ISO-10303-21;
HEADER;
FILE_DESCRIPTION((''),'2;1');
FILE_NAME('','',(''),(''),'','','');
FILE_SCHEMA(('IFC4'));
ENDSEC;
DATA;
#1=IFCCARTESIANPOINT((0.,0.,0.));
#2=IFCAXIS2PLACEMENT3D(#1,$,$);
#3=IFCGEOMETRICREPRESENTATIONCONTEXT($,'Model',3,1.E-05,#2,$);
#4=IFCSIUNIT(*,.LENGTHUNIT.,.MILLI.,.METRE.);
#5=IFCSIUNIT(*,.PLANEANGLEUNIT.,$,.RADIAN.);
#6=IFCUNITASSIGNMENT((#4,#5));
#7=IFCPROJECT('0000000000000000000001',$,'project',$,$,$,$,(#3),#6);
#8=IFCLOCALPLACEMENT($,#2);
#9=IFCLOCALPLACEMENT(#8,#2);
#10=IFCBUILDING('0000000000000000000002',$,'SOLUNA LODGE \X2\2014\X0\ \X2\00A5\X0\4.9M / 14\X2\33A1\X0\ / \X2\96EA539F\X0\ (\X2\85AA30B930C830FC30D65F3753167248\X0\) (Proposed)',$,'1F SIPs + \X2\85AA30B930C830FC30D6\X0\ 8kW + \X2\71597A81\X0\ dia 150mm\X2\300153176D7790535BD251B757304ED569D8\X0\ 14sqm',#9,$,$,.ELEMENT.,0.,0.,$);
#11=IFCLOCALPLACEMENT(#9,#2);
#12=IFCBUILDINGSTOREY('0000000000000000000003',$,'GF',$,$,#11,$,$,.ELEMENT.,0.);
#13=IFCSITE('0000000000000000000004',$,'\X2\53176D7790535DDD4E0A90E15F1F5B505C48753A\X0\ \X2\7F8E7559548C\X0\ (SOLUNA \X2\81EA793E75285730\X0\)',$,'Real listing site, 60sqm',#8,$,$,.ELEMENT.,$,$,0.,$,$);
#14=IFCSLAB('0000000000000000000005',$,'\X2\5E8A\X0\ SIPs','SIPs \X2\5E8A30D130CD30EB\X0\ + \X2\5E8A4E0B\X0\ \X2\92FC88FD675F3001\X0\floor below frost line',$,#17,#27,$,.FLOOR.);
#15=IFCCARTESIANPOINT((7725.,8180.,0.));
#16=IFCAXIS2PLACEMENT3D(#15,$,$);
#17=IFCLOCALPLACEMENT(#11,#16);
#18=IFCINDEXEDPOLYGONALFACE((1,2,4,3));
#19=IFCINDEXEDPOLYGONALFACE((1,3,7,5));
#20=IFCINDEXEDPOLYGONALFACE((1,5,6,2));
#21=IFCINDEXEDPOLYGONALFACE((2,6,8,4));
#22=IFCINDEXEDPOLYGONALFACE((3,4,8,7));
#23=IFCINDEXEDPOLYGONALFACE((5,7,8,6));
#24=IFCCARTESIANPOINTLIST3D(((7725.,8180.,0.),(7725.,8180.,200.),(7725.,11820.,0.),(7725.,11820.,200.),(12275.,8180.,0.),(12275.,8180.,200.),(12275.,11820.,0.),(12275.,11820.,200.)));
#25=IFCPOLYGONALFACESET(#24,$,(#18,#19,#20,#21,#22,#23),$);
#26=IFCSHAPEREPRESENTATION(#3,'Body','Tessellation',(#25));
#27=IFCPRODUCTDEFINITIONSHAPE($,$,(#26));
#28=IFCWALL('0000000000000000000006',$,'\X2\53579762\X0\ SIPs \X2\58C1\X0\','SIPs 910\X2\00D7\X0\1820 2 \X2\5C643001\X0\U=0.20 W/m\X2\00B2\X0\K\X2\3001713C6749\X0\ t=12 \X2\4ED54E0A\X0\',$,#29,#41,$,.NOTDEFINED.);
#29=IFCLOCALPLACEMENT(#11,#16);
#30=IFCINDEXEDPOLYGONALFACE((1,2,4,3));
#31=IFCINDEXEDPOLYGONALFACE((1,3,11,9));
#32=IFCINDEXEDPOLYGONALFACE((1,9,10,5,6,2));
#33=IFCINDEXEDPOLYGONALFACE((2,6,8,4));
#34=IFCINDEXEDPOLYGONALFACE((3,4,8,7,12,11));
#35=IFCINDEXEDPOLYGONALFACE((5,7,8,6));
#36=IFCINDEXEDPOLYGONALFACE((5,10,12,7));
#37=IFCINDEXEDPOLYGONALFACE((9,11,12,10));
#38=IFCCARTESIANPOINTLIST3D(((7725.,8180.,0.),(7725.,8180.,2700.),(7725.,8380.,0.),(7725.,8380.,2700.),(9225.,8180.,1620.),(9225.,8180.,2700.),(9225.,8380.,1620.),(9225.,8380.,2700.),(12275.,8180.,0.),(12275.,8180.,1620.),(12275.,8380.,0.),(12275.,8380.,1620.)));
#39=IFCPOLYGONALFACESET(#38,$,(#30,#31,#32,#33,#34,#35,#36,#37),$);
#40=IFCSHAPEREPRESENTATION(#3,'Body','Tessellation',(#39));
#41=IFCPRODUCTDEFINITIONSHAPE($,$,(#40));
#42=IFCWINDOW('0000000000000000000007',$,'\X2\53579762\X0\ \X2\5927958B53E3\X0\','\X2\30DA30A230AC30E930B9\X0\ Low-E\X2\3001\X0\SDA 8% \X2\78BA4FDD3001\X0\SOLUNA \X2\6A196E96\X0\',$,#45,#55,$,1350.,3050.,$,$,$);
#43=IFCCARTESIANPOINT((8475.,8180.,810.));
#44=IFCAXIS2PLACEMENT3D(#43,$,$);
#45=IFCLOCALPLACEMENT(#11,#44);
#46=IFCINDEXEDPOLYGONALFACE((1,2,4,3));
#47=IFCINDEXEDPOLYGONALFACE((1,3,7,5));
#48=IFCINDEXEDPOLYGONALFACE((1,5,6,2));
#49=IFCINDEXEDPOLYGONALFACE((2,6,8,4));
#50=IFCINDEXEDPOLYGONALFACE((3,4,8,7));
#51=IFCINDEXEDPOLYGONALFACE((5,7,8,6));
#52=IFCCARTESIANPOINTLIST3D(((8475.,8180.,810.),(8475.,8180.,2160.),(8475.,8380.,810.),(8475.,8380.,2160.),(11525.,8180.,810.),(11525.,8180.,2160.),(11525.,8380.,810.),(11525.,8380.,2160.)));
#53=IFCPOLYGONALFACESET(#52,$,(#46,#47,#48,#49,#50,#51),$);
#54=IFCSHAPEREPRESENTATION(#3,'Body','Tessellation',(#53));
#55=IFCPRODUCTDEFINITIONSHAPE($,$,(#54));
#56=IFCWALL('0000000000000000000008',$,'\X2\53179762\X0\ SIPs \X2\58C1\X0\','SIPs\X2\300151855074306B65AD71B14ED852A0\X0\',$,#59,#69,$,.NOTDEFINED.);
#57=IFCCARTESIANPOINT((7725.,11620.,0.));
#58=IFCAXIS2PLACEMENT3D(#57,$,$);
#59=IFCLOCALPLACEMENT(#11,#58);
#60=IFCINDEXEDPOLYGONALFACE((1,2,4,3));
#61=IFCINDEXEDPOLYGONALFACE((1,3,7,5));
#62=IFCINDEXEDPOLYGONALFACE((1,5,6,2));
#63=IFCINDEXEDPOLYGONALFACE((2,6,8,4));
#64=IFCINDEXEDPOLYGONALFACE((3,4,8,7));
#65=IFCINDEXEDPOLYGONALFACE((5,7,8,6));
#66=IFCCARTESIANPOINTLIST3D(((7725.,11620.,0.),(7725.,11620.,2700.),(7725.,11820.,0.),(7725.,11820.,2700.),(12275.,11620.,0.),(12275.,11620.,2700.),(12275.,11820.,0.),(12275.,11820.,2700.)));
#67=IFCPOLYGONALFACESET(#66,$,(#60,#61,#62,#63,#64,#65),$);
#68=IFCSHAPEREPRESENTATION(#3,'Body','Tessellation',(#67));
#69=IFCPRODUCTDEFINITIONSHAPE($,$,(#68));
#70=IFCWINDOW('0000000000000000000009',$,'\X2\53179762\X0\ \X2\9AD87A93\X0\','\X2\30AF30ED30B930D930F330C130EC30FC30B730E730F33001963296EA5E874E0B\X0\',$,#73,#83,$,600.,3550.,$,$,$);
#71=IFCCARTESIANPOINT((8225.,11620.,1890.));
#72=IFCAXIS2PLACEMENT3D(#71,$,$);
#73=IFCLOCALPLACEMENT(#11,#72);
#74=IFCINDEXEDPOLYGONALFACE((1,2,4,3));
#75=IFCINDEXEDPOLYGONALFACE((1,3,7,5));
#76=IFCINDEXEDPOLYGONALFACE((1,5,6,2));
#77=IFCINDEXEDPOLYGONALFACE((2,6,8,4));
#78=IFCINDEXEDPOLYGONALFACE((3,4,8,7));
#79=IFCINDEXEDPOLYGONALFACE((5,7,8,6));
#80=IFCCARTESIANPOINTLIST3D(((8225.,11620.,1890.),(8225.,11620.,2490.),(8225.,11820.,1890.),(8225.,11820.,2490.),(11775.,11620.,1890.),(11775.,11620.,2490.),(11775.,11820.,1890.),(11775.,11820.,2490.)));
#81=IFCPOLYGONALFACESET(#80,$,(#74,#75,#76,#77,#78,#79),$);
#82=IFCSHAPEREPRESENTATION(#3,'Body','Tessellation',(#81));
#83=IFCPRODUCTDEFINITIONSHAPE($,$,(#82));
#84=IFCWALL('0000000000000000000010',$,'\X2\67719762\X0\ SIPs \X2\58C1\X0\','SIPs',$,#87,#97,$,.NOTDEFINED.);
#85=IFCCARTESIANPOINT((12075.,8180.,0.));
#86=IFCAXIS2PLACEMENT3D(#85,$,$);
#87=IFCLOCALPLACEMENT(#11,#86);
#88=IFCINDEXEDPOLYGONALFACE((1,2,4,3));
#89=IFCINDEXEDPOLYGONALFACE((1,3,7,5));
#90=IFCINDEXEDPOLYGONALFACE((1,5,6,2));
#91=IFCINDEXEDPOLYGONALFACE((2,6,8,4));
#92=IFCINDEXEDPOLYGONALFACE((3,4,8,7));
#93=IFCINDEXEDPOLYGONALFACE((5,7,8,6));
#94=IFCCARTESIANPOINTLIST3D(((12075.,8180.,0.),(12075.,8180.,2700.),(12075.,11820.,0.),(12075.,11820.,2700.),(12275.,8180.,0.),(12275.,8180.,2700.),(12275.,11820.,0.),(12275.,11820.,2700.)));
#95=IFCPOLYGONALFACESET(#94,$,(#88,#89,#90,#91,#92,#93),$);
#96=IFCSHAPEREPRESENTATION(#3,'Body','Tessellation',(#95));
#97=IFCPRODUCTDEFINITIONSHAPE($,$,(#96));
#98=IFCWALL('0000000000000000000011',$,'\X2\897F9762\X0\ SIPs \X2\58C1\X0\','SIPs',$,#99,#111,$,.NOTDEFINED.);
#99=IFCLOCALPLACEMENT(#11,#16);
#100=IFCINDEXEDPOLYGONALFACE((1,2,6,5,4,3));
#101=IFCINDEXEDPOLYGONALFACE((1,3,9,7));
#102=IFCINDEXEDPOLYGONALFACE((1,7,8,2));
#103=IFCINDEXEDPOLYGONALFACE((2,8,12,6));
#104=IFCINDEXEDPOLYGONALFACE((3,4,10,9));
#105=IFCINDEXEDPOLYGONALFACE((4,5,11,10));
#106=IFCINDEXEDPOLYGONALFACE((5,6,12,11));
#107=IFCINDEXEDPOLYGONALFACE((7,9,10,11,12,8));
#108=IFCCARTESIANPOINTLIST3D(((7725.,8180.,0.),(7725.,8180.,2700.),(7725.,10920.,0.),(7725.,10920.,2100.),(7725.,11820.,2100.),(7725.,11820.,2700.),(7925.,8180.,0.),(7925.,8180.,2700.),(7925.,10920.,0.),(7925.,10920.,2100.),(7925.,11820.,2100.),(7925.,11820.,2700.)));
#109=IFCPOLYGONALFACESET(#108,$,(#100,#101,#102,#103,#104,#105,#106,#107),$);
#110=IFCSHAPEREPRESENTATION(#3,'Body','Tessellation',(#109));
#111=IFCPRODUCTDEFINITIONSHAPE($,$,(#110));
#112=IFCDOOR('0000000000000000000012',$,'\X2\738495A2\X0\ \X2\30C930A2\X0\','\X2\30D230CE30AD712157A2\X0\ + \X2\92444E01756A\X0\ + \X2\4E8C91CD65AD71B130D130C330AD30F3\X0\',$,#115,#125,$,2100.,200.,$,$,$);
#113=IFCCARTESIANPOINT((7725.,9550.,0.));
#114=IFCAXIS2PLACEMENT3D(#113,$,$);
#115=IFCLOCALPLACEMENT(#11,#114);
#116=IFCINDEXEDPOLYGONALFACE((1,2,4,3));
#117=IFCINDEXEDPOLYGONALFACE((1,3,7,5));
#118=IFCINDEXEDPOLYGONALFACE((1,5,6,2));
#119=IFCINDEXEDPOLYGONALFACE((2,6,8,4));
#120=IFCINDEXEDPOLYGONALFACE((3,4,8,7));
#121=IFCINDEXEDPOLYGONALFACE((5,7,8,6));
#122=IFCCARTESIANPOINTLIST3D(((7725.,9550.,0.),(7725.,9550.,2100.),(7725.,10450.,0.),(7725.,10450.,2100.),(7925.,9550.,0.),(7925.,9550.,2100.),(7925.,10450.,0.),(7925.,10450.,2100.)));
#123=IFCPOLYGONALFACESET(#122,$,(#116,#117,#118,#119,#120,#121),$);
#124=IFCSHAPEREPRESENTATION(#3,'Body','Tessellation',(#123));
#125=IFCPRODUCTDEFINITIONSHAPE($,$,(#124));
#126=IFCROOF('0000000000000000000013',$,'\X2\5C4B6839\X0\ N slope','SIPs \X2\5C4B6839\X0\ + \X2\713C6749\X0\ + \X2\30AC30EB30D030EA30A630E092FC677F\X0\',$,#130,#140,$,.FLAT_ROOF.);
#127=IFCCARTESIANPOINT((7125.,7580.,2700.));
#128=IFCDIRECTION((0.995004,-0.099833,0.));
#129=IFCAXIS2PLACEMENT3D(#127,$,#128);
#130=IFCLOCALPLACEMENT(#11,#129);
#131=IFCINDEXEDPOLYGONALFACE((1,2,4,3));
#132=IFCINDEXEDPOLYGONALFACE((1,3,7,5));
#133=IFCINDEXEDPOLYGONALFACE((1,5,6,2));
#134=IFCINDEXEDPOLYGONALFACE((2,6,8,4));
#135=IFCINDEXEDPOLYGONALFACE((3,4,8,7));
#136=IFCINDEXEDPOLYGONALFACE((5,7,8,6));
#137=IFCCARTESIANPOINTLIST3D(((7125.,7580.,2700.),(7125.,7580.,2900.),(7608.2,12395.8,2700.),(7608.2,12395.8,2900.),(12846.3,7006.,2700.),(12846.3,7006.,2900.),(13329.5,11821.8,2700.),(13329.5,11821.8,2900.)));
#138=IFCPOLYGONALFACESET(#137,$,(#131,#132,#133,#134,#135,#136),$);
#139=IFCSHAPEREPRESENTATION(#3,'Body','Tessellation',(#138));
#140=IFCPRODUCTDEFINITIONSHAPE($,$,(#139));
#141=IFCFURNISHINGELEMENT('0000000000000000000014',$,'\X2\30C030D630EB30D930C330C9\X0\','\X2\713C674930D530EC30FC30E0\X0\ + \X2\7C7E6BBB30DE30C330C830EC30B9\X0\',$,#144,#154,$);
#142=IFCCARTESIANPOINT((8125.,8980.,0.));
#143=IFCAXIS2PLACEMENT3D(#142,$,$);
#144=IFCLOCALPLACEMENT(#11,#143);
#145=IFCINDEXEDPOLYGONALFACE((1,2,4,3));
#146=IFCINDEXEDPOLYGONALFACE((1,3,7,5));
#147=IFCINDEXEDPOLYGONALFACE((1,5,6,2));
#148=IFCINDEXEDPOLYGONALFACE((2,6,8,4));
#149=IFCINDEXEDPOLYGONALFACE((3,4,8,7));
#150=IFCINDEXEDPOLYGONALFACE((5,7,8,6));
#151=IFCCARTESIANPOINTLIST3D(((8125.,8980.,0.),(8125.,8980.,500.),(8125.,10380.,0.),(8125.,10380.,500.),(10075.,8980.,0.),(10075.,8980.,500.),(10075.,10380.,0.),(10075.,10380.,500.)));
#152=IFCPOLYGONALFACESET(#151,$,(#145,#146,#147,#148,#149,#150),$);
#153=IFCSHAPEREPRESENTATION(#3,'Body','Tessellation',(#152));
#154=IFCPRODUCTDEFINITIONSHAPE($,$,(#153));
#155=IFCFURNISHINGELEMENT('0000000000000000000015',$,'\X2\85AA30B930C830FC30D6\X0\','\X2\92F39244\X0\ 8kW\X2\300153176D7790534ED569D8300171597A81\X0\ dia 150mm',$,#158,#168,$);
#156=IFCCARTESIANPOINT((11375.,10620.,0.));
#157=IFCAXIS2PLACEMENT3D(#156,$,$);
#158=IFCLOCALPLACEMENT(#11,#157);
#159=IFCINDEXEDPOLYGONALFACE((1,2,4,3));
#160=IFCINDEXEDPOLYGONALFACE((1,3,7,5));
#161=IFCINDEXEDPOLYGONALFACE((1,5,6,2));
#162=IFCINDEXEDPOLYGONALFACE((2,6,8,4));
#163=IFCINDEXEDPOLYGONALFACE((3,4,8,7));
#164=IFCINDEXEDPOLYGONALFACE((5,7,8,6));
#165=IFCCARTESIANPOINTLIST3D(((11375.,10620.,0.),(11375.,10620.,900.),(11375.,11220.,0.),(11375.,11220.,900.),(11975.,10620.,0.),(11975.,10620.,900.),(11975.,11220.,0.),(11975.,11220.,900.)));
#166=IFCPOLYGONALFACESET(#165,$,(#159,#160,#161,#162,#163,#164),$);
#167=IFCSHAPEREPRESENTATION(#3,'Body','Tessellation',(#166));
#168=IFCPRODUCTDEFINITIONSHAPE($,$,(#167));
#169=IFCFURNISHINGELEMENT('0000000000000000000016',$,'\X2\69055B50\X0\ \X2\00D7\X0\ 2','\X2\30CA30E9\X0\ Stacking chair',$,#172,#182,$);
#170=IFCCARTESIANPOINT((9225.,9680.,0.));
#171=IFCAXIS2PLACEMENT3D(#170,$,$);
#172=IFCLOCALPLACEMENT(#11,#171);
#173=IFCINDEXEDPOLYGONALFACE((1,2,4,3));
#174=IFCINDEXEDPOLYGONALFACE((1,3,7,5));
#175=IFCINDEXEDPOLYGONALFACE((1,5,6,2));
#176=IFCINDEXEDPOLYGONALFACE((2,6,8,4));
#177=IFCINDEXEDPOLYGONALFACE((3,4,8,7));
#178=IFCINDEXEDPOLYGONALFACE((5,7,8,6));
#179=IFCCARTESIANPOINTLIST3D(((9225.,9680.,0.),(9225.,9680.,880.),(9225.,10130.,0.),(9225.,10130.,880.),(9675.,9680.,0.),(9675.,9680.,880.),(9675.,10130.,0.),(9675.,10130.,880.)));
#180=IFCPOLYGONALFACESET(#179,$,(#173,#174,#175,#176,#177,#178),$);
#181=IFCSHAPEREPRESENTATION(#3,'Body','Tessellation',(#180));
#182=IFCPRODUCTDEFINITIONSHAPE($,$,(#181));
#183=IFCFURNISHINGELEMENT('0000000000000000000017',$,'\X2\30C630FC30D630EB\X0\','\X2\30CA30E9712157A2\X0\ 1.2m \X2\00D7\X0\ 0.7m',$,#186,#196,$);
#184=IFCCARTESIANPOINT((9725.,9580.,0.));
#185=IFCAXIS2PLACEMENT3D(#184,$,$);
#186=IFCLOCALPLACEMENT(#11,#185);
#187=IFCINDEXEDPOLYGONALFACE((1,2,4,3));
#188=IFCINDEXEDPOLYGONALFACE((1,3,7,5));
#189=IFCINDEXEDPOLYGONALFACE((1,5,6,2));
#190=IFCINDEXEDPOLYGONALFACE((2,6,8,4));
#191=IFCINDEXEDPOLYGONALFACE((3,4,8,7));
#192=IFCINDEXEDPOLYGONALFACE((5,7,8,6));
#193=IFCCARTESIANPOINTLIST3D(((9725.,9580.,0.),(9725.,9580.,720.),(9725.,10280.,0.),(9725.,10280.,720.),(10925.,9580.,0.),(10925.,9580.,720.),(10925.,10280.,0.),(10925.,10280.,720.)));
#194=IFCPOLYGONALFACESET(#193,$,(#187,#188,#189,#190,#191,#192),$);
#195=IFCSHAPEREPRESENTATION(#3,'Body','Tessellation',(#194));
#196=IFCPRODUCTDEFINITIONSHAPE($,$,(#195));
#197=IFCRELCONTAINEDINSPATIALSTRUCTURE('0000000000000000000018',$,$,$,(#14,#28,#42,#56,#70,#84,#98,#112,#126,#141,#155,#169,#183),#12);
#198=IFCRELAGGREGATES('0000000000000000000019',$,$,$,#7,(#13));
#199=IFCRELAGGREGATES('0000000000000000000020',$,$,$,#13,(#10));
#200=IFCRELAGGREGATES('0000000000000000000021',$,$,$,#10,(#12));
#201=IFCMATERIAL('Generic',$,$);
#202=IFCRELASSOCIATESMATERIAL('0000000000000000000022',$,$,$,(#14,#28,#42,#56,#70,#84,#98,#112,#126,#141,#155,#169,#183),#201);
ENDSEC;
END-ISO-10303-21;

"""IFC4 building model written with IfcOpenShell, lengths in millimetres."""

from ifc_helpers import new_model, si_unit, frame, frame_2d, origin, place, context, project, spatial, rectangle, extrude, material, element, fill, save


model = new_model("IFC4")

# Units and contexts
model_context = context("Model", 3, precision=1e-05, world=origin())
ifc_project = project(units=[si_unit("LENGTHUNIT", "METRE", prefix="MILLI"), si_unit("PLANEANGLEUNIT", "RADIAN")], contexts=[model_context])

# Site, building, storey
site_placement = place(None, origin())
site = spatial("IfcSite", under=ifc_project, at=site_placement, Name="北海道川上郡弟子屈町 美留和 (SOLUNA 自社用地)", ObjectType="Real listing site, 60sqm", CompositionType="ELEMENT", RefElevation=0.0)
building_placement = place(site_placement, origin())
building = spatial("IfcBuilding", under=site, at=building_placement, Name="SOLUNA LODGE — ¥4.9M / 14㎡ / 雪原 (薪ストーブ強化版) (Proposed)", ObjectType="1F SIPs + 薪ストーブ 8kW + 煙突 dia 150mm、北海道寒冷地仕様 14sqm", CompositionType="ELEMENT", ElevationOfRefHeight=0.0, ElevationOfTerrain=0.0)
storey_placement = place(building_placement, origin())
storey = spatial("IfcBuildingStorey", under=building, at=storey_placement, Name="GF", CompositionType="ELEMENT", Elevation=0.0)

# Slab
ifc_material = material(Name="Generic")
slab_placement = place(storey_placement, frame((7725.0, 8180.0, 0.0)))
element("IfcSlab", 1, at=slab_placement, inside=storey, material=ifc_material, Name="床 SIPs", Description="SIPs 床パネル + 床下 鋼製束、floor below frost line", PredefinedType="FLOOR", context=model_context, shape_type="SweptSolid", body=[
    extrude(rectangle(XDim=4550.0, YDim=3640.0, at=frame_2d((2275.0, 1820.0))), frame((7725.0, 8180.0, 0.0)), (0.0, 0.0, 1.0), 200.0),
])

# Walls, openings, windows
wall_1_placement = place(storey_placement, frame((7725.0, 8180.0, 0.0)))
wall_1 = element("IfcWall", 2, at=wall_1_placement, inside=storey, material=ifc_material, Name="南面 SIPs 壁", Description="SIPs 910×1820 2 層、U=0.20 W/m²K、焼杉 t=12 仕上", PredefinedType="NOTDEFINED", context=model_context, shape_type="SweptSolid", body=[
    extrude(rectangle(XDim=4550.0, YDim=200.0, at=frame_2d((2275.0, 100.0))), frame((7725.0, 8180.0, 0.0)), (0.0, 0.0, 1.0), 2700.0),
])
opening_1_placement = place(storey_placement, frame((8475.0, 8180.0, 810.0)))
opening_1 = element("IfcOpeningElement", 3, at=opening_1_placement, cuts=wall_1, PredefinedType="NOTDEFINED", context=model_context, shape_type="SweptSolid", body=[
    extrude(rectangle(XDim=3050.0, YDim=200.0, at=frame_2d((1525.0, 100.0))), frame((8475.0, 8180.0, 810.0)), (0.0, 0.0, 1.0), 1350.0),
])
window_1_placement = place(storey_placement, frame((8475.0, 8180.0, 810.0)))
window_1 = element("IfcWindow", 4, at=window_1_placement, inside=storey, material=ifc_material, Name="南面 大開口", Description="ペアガラス Low-E、SDA 8% 確保、SOLUNA 標準", OverallHeight=1350.0, OverallWidth=3050.0, context=model_context, shape_type="SweptSolid", body=[
    extrude(rectangle(XDim=3050.0, YDim=200.0, at=frame_2d((1525.0, 100.0))), frame((8475.0, 8180.0, 810.0)), (0.0, 0.0, 1.0), 1350.0),
])
fill(opening_1, window_1)
wall_2_placement = place(storey_placement, frame((7725.0, 11620.0, 0.0)))
wall_2 = element("IfcWall", 5, at=wall_2_placement, inside=storey, material=ifc_material, Name="北面 SIPs 壁", Description="SIPs、内側に断熱付加", PredefinedType="NOTDEFINED", context=model_context, shape_type="SweptSolid", body=[
    extrude(rectangle(XDim=4550.0, YDim=200.0, at=frame_2d((2275.0, 100.0))), frame((7725.0, 11620.0, 0.0)), (0.0, 0.0, 1.0), 2700.0),
])
opening_2_placement = place(storey_placement, frame((8225.0, 11620.0, 1890.0)))
opening_2 = element("IfcOpeningElement", 6, at=opening_2_placement, cuts=wall_2, PredefinedType="NOTDEFINED", context=model_context, shape_type="SweptSolid", body=[
    extrude(rectangle(XDim=3550.0, YDim=200.0, at=frame_2d((1775.0, 100.0))), frame((8225.0, 11620.0, 1890.0)), (0.0, 0.0, 1.0), 600.0),
])
window_2_placement = place(storey_placement, frame((8225.0, 11620.0, 1890.0)))
window_2 = element("IfcWindow", 7, at=window_2_placement, inside=storey, material=ifc_material, Name="北面 高窓", Description="クロスベンチレーション、防雪庇下", OverallHeight=600.0, OverallWidth=3550.0, context=model_context, shape_type="SweptSolid", body=[
    extrude(rectangle(XDim=3550.0, YDim=200.0, at=frame_2d((1775.0, 100.0))), frame((8225.0, 11620.0, 1890.0)), (0.0, 0.0, 1.0), 600.0),
])
fill(opening_2, window_2)

# Wall
wall_3_placement = place(storey_placement, frame((12075.0, 8180.0, 0.0)))
element("IfcWall", 8, at=wall_3_placement, inside=storey, material=ifc_material, Name="東面 SIPs 壁", Description="SIPs", PredefinedType="NOTDEFINED", context=model_context, shape_type="SweptSolid", body=[
    extrude(rectangle(XDim=200.0, YDim=3640.0, at=frame_2d((100.0, 1820.0))), frame((12075.0, 8180.0, 0.0)), (0.0, 0.0, 1.0), 2700.0),
])

# Wall, opening, door
wall_4_placement = place(storey_placement, frame((7725.0, 8180.0, 0.0)))
wall_4 = element("IfcWall", 9, at=wall_4_placement, inside=storey, material=ifc_material, Name="西面 SIPs 壁", Description="SIPs", PredefinedType="NOTDEFINED", context=model_context, shape_type="SweptSolid", body=[
    extrude(rectangle(XDim=200.0, YDim=3640.0, at=frame_2d((100.0, 1820.0))), frame((7725.0, 8180.0, 0.0)), (0.0, 0.0, 1.0), 2700.0),
])
opening_3_placement = place(storey_placement, frame((7725.0, 9550.0, 0.0)))
opening_3 = element("IfcOpeningElement", 10, at=opening_3_placement, cuts=wall_4, PredefinedType="NOTDEFINED", context=model_context, shape_type="SweptSolid", body=[
    extrude(rectangle(XDim=200.0, YDim=900.0, at=frame_2d((100.0, 450.0))), frame((7725.0, 9550.0, 0.0)), (0.0, 0.0, 1.0), 2100.0),
])
door_placement = place(storey_placement, frame((7725.0, 9550.0, 0.0)))
door = element("IfcDoor", 11, at=door_placement, inside=storey, material=ifc_material, Name="玄関 ドア", Description="ヒノキ無垢 + 鉄丁番 + 二重断熱パッキン", OverallHeight=2100.0, OverallWidth=200.0, context=model_context, shape_type="SweptSolid", body=[
    extrude(rectangle(XDim=200.0, YDim=900.0, at=frame_2d((100.0, 450.0))), frame((7725.0, 9550.0, 0.0)), (0.0, 0.0, 1.0), 2100.0),
])
fill(opening_3, door)

# Roof
roof_placement = place(storey_placement, frame((7125.0, 7580.0, 2700.0), x_axis=(0.995004, -0.099833, 0.0)))
element("IfcRoof", 12, at=roof_placement, inside=storey, material=ifc_material, Name="屋根 N slope", Description="SIPs 屋根 + 焼杉 + ガルバリウム鋼板", PredefinedType="FLAT_ROOF", context=model_context, shape_type="SweptSolid", body=[
    extrude(rectangle(XDim=5750.0, YDim=4840.0, at=frame_2d((2875.0, 2420.0))), frame((7125.0, 7580.0, 2700.0), x_axis=(0.995004, -0.099833, 0.0)), (0.0, 0.0, 1.0), 200.0),
])

# Furnishing elements
furnishing_1_placement = place(storey_placement, frame((8125.0, 8980.0, 0.0)))
element("IfcFurnishingElement", 13, at=furnishing_1_placement, inside=storey, material=ifc_material, Name="ダブルベッド", Description="焼杉フレーム + 籾殻マットレス", context=model_context, shape_type="SweptSolid", body=[
    extrude(rectangle(XDim=1950.0, YDim=1400.0, at=frame_2d((975.0, 700.0))), frame((8125.0, 8980.0, 0.0)), (0.0, 0.0, 1.0), 500.0),
])
furnishing_2_placement = place(storey_placement, frame((11375.0, 10620.0, 0.0)))
element("IfcFurnishingElement", 14, at=furnishing_2_placement, inside=storey, material=ifc_material, Name="薪ストーブ", Description="鋳鉄 8kW、北海道仕様、煙突 dia 150mm", context=model_context, shape_type="SweptSolid", body=[
    extrude(rectangle(XDim=600.0, YDim=600.0, at=frame_2d((300.0, 300.0))), frame((11375.0, 10620.0, 0.0)), (0.0, 0.0, 1.0), 900.0),
])
furnishing_3_placement = place(storey_placement, frame((9225.0, 9680.0, 0.0)))
element("IfcFurnishingElement", 15, at=furnishing_3_placement, inside=storey, material=ifc_material, Name="椅子 × 2", Description="ナラ Stacking chair", context=model_context, shape_type="SweptSolid", body=[
    extrude(rectangle(XDim=450.0, YDim=450.0, at=frame_2d((225.0, 225.0))), frame((9225.0, 9680.0, 0.0)), (0.0, 0.0, 1.0), 880.0),
])
furnishing_4_placement = place(storey_placement, frame((9725.0, 9580.0, 0.0)))
element("IfcFurnishingElement", 16, at=furnishing_4_placement, inside=storey, material=ifc_material, Name="テーブル", Description="ナラ無垢 1.2m × 0.7m", context=model_context, shape_type="SweptSolid", body=[
    extrude(rectangle(XDim=1200.0, YDim=700.0, at=frame_2d((600.0, 350.0))), frame((9725.0, 9580.0, 0.0)), (0.0, 0.0, 1.0), 720.0),
])

save(model, "model.ifc")
